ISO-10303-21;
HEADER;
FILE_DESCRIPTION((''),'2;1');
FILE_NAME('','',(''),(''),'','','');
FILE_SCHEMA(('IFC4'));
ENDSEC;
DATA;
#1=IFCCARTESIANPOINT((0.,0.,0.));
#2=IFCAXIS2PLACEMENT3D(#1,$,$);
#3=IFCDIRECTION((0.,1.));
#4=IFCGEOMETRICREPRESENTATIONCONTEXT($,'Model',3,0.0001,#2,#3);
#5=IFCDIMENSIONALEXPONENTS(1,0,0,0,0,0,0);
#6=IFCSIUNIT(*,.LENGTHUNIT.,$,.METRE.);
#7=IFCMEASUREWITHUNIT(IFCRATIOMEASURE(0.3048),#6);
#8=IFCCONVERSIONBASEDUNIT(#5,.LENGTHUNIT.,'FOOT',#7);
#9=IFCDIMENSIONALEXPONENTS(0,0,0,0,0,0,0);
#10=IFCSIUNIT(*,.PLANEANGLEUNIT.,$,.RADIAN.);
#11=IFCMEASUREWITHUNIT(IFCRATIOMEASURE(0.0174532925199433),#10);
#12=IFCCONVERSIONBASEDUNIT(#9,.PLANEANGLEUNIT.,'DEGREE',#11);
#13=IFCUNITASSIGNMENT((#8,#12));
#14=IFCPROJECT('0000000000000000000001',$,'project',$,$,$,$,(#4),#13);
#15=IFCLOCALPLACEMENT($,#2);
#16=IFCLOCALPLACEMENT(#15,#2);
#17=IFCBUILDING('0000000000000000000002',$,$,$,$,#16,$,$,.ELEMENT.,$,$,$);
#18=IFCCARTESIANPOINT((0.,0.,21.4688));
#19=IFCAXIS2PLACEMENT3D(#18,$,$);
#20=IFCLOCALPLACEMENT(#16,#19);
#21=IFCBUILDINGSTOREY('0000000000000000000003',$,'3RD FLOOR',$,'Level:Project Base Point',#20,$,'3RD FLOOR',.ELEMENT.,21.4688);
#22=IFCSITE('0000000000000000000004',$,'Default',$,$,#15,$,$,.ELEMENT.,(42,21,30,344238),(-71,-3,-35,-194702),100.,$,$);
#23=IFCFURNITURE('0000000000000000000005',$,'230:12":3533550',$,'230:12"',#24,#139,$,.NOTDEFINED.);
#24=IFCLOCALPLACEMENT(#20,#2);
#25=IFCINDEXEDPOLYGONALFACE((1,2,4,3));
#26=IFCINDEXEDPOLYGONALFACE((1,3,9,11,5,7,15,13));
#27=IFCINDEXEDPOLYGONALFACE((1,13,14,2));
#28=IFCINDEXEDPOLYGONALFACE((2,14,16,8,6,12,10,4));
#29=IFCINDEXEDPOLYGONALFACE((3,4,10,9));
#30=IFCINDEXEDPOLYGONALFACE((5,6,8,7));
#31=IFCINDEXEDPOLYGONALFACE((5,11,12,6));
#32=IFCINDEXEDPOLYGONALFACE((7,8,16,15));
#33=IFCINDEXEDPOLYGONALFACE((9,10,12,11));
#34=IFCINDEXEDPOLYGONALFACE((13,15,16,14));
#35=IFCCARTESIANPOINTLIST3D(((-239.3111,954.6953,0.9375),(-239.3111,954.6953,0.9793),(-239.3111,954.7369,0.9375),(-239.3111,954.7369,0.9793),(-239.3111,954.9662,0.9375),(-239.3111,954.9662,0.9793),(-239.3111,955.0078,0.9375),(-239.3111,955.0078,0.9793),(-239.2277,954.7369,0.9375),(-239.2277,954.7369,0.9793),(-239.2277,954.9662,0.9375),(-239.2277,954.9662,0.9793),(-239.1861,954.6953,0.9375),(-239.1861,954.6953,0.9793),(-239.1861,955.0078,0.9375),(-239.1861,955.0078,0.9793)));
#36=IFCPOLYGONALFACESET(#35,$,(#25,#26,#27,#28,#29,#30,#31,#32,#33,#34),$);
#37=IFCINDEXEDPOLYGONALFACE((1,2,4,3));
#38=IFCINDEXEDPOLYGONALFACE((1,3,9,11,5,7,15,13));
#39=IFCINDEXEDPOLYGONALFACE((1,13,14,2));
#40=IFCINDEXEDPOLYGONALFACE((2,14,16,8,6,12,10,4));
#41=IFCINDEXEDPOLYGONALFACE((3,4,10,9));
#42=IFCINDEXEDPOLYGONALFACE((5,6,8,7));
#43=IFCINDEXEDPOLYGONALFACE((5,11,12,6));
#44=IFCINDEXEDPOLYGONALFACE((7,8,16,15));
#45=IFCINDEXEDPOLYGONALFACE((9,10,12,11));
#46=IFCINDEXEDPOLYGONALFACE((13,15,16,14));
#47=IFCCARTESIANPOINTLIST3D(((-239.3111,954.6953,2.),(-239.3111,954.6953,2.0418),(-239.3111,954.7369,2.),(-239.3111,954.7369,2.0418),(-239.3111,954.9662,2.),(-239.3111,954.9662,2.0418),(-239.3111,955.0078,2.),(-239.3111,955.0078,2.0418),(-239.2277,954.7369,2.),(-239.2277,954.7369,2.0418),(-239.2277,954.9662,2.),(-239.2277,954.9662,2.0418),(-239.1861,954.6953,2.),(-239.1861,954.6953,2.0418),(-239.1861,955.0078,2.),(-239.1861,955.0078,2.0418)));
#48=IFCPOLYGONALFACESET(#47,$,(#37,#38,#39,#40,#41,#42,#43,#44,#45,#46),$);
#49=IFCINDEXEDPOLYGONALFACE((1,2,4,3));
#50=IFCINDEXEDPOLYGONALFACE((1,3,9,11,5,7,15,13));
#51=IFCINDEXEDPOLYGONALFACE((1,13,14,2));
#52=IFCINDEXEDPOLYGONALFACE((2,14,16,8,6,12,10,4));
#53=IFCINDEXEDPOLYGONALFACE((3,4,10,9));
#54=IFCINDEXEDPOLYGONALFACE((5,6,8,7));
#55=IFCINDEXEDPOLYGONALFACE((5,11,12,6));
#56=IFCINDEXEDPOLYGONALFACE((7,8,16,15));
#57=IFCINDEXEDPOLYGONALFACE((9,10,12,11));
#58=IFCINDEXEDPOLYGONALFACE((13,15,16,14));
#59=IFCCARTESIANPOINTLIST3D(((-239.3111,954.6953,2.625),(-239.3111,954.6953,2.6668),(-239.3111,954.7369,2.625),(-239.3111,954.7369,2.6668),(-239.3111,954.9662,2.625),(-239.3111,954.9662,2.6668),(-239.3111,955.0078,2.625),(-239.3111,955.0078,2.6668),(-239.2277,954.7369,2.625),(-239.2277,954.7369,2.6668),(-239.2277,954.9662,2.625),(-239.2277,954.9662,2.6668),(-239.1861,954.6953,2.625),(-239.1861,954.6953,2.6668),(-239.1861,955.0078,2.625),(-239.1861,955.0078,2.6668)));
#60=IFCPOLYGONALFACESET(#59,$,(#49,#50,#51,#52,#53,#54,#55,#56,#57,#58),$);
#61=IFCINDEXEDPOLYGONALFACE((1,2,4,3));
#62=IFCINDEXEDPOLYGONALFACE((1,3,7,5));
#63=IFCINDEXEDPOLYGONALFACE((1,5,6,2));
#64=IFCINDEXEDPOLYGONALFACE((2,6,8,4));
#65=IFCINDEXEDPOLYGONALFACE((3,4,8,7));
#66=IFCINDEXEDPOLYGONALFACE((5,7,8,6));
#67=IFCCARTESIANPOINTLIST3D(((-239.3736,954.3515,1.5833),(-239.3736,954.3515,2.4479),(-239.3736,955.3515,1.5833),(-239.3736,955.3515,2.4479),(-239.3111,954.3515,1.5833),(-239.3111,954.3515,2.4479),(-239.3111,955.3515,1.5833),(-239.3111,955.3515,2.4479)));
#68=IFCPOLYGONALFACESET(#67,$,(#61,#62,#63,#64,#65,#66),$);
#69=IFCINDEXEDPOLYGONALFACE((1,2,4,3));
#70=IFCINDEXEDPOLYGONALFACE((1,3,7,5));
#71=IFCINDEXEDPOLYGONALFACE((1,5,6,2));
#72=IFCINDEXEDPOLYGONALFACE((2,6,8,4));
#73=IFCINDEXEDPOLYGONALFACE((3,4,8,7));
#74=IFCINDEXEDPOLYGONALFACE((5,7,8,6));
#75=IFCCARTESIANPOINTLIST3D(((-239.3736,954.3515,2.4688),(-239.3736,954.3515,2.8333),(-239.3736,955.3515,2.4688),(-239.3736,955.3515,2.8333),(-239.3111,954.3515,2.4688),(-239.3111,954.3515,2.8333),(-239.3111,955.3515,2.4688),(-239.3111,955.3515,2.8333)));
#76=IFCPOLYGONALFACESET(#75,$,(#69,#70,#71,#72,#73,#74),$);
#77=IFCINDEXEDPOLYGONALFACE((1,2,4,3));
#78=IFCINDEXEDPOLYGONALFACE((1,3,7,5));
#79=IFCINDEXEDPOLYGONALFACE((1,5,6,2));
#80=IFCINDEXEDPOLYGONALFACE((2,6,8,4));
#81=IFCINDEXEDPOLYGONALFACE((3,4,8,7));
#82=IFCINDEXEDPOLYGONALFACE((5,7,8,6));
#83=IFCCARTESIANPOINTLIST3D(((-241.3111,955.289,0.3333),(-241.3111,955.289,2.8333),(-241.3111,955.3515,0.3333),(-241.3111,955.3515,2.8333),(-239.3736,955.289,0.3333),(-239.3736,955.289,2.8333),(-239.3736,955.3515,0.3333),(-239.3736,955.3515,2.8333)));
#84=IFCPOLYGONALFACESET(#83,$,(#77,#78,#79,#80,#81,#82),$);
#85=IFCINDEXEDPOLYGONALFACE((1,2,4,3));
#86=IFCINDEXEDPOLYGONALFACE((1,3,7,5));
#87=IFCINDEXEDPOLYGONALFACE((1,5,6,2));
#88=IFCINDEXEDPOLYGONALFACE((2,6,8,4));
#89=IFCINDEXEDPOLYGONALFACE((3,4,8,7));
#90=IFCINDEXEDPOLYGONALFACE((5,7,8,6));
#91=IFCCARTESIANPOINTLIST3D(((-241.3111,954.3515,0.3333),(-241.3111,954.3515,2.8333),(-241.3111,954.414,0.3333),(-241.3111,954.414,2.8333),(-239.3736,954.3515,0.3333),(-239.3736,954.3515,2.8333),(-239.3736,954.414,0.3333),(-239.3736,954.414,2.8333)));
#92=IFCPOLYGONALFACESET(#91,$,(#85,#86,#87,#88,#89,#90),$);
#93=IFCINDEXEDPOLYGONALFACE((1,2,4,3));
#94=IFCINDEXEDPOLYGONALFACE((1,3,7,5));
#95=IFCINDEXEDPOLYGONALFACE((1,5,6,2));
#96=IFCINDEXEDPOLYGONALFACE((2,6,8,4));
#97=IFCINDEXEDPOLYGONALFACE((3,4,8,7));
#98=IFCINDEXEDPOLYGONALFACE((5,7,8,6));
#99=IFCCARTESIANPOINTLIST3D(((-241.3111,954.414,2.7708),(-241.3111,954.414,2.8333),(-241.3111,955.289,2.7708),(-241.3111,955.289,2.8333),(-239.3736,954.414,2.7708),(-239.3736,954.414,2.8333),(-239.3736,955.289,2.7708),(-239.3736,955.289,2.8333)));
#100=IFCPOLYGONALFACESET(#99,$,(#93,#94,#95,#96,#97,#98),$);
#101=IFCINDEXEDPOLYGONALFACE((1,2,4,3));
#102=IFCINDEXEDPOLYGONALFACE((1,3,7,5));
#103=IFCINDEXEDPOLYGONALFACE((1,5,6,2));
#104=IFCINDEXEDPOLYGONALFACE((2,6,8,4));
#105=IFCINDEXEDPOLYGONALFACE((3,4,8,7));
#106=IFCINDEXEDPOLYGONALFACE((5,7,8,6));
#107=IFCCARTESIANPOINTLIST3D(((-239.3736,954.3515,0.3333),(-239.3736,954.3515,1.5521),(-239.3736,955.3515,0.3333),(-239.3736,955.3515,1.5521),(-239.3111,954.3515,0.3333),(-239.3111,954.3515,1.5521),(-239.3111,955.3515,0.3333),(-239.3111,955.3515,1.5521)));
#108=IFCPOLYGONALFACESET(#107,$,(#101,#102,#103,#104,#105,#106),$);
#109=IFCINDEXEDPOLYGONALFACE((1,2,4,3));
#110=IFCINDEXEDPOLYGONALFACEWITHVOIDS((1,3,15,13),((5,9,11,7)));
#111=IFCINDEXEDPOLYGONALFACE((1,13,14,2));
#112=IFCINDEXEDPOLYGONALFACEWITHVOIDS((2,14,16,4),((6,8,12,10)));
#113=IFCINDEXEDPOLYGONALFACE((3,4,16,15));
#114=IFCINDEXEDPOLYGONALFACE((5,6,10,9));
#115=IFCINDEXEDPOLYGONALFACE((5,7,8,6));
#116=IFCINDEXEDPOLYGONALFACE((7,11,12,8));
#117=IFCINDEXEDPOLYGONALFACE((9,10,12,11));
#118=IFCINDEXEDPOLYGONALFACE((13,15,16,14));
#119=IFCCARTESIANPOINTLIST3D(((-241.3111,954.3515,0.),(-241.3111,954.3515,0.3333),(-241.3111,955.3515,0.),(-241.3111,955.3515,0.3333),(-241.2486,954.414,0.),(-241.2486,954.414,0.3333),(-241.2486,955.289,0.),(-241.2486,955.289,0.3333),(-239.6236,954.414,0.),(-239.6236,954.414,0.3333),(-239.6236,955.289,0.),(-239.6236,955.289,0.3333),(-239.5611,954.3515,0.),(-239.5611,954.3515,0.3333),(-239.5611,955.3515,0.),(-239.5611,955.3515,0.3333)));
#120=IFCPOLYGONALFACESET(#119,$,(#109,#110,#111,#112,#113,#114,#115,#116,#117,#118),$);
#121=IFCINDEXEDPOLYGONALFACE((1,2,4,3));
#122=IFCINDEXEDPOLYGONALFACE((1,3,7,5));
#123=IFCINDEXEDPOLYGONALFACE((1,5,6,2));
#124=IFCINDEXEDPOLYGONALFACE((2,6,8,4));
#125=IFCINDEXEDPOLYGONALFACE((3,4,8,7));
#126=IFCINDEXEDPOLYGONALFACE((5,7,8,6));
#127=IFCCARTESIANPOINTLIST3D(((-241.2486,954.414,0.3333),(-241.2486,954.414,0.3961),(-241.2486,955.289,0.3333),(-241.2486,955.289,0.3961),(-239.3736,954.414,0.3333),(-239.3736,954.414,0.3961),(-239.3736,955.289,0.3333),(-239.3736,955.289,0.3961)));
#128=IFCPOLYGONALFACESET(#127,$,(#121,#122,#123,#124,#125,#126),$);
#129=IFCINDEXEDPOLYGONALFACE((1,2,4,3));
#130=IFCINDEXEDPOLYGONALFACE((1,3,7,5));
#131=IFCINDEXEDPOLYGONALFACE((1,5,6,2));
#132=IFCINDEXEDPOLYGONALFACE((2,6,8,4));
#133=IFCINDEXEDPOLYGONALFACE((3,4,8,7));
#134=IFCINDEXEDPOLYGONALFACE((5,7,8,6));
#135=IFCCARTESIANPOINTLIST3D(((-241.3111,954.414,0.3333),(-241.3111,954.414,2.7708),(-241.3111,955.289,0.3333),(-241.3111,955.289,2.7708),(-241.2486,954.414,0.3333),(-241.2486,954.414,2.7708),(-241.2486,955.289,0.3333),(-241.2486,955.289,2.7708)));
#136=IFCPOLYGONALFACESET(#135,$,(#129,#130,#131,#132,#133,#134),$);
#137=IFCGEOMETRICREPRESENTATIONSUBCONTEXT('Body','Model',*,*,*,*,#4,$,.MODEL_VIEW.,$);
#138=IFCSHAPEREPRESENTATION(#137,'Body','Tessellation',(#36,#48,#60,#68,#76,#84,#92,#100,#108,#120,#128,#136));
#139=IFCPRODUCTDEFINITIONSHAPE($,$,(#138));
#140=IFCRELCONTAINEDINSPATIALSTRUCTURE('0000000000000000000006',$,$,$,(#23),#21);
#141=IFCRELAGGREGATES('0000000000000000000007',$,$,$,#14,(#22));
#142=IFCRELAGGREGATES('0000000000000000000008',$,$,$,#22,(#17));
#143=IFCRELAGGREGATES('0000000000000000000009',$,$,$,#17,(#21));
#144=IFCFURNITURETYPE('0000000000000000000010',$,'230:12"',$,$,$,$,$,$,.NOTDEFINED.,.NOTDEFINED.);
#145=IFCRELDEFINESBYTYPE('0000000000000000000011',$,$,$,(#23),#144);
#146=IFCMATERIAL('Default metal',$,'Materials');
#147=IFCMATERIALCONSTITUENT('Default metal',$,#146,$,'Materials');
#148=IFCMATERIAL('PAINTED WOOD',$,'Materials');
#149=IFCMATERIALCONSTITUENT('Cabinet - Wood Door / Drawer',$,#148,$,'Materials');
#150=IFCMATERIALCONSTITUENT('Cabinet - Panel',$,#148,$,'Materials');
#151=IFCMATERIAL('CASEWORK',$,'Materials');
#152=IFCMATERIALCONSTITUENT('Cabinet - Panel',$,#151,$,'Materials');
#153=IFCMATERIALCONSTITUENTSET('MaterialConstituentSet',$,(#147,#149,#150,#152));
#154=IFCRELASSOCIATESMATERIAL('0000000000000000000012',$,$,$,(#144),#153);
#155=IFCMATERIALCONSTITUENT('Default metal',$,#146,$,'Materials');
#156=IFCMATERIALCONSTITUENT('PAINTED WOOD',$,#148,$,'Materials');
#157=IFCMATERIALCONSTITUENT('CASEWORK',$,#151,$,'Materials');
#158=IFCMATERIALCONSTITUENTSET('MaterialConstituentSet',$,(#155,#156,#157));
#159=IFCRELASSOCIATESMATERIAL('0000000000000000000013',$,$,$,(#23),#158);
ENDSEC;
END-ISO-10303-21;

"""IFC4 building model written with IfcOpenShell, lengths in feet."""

from ifc_helpers import new_model, entity, si_unit, converted_unit, direction, frame, frame_2d, origin, origin_2d_with_axis, place, context, subcontext, project, spatial, polyline, rectangle, outline, extrude, source, transform, mapped, material, constituent, constituent_set, type_object, type_shapes, element, save


model = new_model("IFC4")

# Units and contexts
model_context = context("Model", 3, precision=0.0001, world=origin(), true_north=direction((0.0, 1.0)))
body_context = subcontext(model_context, "Body", "Model", "MODEL_VIEW")
ifc_project = project(units=[converted_unit("LENGTHUNIT", "FOOT", entity("IfcRatioMeasure", 0.3048), si_unit("LENGTHUNIT", "METRE"), dimensions=[1, 0, 0, 0, 0, 0, 0]), converted_unit("PLANEANGLEUNIT", "DEGREE", entity("IfcRatioMeasure", 0.0174532925199433), si_unit("PLANEANGLEUNIT", "RADIAN"), dimensions=[0, 0, 0, 0, 0, 0, 0])], contexts=[model_context])

# Site, building, storey
site_placement = place(None, origin())
site = spatial("IfcSite", under=ifc_project, at=site_placement, Name="Default", CompositionType="ELEMENT", RefLatitude=(42, 21, 30, 344238), RefLongitude=(-71, -3, -35, -194702), RefElevation=100.0)
building_placement = place(site_placement, origin())
building = spatial("IfcBuilding", under=site, at=building_placement, CompositionType="ELEMENT")
storey_placement = place(building_placement, frame((0.0, 0.0, 21.4688)))
storey = spatial("IfcBuildingStorey", under=building, at=storey_placement, Name="3RD FLOOR", ObjectType="Level:Project Base Point", LongName="3RD FLOOR", CompositionType="ELEMENT", Elevation=21.4688)

# Furniture
ifc_material_1 = material(Name="Default metal", Category="Materials")
ifc_material_2 = material(Name="PAINTED WOOD", Category="Materials")
ifc_material_3 = material(Name="CASEWORK", Category="Materials")
ifc_constituent_1 = constituent(ifc_material_1, Name="Default metal", Category="Materials")
ifc_constituent_2 = constituent(ifc_material_2, Name="PAINTED WOOD", Category="Materials")
ifc_constituent_3 = constituent(ifc_material_3, Name="CASEWORK", Category="Materials")
ifc_constituent_set_1 = constituent_set(constituents=[ifc_constituent_1, ifc_constituent_2, ifc_constituent_3], Name="MaterialConstituentSet")
ifc_constituent_4 = constituent(ifc_material_1, Name="Default metal", Category="Materials")
ifc_constituent_5 = constituent(ifc_material_2, Name="Cabinet - Wood Door / Drawer", Category="Materials")
ifc_constituent_6 = constituent(ifc_material_2, Name="Cabinet - Panel", Category="Materials")
ifc_constituent_7 = constituent(ifc_material_3, Name="Cabinet - Panel", Category="Materials")
ifc_constituent_set_2 = constituent_set(constituents=[ifc_constituent_4, ifc_constituent_5, ifc_constituent_6, ifc_constituent_7], Name="MaterialConstituentSet")
furniture_type_1 = type_object("IfcFurnitureType", Name="230:12\"", AssemblyPlace="NOTDEFINED", PredefinedType="NOTDEFINED", material=ifc_constituent_set_2)
shared_shape_1 = source(origin(), body_context, "Body", "SweptSolid", [
    extrude(outline(polyline([(-0.1562, -0.0521), (-0.1146, -0.0521), (-0.1146, 0.0313), (0.1146, 0.0313), (0.1146, -0.0521), (0.1562, -0.0521), (0.1562, 0.0729), (-0.1562, 0.0729), (-0.1562, -0.0521)])), frame((0.0615, 2.0521, 0.9375)), (0.0, 0.0, 1.0), 0.0418),
    extrude(outline(polyline([(-0.1562, -0.0521), (-0.1146, -0.0521), (-0.1146, 0.0313), (0.1146, 0.0313), (0.1146, -0.0521), (0.1562, -0.0521), (0.1562, 0.0729), (-0.1562, 0.0729), (-0.1562, -0.0521)])), frame((0.0615, 2.0521, 2.0)), (0.0, 0.0, 1.0), 0.0418),
    extrude(outline(polyline([(-0.1562, -0.0521), (-0.1146, -0.0521), (-0.1146, 0.0313), (0.1146, 0.0313), (0.1146, -0.0521), (0.1562, -0.0521), (0.1562, 0.0729), (-0.1562, 0.0729), (-0.1562, -0.0521)])), frame((0.0615, 2.0521, 2.625)), (0.0, 0.0, 1.0), 0.0418),
    extrude(rectangle(XDim=1.0, YDim=0.0625, at=origin_2d_with_axis()), frame((0.0615, 1.9688, 1.5833), z_axis=(0.0, 0.0, 1.0), x_axis=(-1.0, 0.0, 0.0)), (0.0, 0.0, 1.0), 0.8646),
    extrude(rectangle(XDim=1.0, YDim=0.0625, at=origin_2d_with_axis()), frame((0.0615, 1.9688, 2.4688), z_axis=(0.0, 0.0, 1.0), x_axis=(-1.0, 0.0, 0.0)), (0.0, 0.0, 1.0), 0.3646),
    extrude(rectangle(XDim=1.9375, YDim=0.0625, at=frame_2d((0.0, 0.0), x_axis=(1.0, 0.0))), frame((-0.4073, 0.9687, 0.3333), z_axis=(0.0, 0.0, 1.0), x_axis=(0.0, -1.0, 0.0)), (0.0, 0.0, 1.0), 2.5),
    extrude(rectangle(XDim=1.9375, YDim=0.0625, at=frame_2d((0.0, 0.0), x_axis=(1.0, 0.0))), frame((0.5302, 0.9687, 0.3333), z_axis=(0.0, 0.0, 1.0), x_axis=(0.0, -1.0, 0.0)), (0.0, 0.0, 1.0), 2.5),
    extrude(rectangle(XDim=1.9375, YDim=0.875, at=origin_2d_with_axis()), frame((0.0615, 0.9687, 2.7708), z_axis=(0.0, 0.0, 1.0), x_axis=(0.0, 1.0, 0.0)), (0.0, 0.0, 1.0), 0.0625),
    extrude(rectangle(XDim=1.0, YDim=0.0625, at=origin_2d_with_axis()), frame((0.0615, 1.9688, 0.3333), z_axis=(0.0, 0.0, 1.0), x_axis=(-1.0, 0.0, 0.0)), (0.0, 0.0, 1.0), 1.2187),
    extrude(outline(polyline([(-0.875, -0.5), (0.875, -0.5), (0.875, 0.5), (-0.875, 0.5), (-0.875, -0.5)]), holes=[polyline([(-0.8125, -0.4375), (-0.8125, 0.4375), (0.8125, 0.4375), (0.8125, -0.4375), (-0.8125, -0.4375)])]), frame((0.0615, 0.875, 0.0), z_axis=(0.0, 0.0, 1.0), x_axis=(0.0, -1.0, 0.0)), (0.0, 0.0, 1.0), 0.3333),
    extrude(rectangle(XDim=1.875, YDim=0.875, at=origin_2d_with_axis()), frame((0.0615, 1.0, 0.3333), z_axis=(0.0, 0.0, 1.0), x_axis=(0.0, 1.0, 0.0)), (0.0, 0.0, 1.0), 0.0627),
    extrude(rectangle(XDim=0.875, YDim=0.0625, at=origin_2d_with_axis()), frame((0.0615, 0.0312, 0.3333), z_axis=(0.0, 0.0, 1.0), x_axis=(-1.0, 0.0, 0.0)), (0.0, 0.0, 1.0), 2.4375),
])
type_shapes(furniture_type_1, [shared_shape_1])
furniture_1_placement = place(storey_placement, frame((-241.3111, 954.913, 0.0), z_axis=(0.0, 0.0, 1.0), x_axis=(0.0, -1.0, 0.0)))
element("IfcFurniture", 1, at=furniture_1_placement, inside=storey, type_object=furniture_type_1, material=ifc_constituent_set_1, Name="230:12\":3533550", ObjectType="230:12\"", PredefinedType="NOTDEFINED", context=body_context, shape_type="MappedRepresentation", body=[
    mapped(shared_shape_1, transform((0.0, 0.0, 0.0), scale=1.0)),
])

save(model, "model.ifc")
